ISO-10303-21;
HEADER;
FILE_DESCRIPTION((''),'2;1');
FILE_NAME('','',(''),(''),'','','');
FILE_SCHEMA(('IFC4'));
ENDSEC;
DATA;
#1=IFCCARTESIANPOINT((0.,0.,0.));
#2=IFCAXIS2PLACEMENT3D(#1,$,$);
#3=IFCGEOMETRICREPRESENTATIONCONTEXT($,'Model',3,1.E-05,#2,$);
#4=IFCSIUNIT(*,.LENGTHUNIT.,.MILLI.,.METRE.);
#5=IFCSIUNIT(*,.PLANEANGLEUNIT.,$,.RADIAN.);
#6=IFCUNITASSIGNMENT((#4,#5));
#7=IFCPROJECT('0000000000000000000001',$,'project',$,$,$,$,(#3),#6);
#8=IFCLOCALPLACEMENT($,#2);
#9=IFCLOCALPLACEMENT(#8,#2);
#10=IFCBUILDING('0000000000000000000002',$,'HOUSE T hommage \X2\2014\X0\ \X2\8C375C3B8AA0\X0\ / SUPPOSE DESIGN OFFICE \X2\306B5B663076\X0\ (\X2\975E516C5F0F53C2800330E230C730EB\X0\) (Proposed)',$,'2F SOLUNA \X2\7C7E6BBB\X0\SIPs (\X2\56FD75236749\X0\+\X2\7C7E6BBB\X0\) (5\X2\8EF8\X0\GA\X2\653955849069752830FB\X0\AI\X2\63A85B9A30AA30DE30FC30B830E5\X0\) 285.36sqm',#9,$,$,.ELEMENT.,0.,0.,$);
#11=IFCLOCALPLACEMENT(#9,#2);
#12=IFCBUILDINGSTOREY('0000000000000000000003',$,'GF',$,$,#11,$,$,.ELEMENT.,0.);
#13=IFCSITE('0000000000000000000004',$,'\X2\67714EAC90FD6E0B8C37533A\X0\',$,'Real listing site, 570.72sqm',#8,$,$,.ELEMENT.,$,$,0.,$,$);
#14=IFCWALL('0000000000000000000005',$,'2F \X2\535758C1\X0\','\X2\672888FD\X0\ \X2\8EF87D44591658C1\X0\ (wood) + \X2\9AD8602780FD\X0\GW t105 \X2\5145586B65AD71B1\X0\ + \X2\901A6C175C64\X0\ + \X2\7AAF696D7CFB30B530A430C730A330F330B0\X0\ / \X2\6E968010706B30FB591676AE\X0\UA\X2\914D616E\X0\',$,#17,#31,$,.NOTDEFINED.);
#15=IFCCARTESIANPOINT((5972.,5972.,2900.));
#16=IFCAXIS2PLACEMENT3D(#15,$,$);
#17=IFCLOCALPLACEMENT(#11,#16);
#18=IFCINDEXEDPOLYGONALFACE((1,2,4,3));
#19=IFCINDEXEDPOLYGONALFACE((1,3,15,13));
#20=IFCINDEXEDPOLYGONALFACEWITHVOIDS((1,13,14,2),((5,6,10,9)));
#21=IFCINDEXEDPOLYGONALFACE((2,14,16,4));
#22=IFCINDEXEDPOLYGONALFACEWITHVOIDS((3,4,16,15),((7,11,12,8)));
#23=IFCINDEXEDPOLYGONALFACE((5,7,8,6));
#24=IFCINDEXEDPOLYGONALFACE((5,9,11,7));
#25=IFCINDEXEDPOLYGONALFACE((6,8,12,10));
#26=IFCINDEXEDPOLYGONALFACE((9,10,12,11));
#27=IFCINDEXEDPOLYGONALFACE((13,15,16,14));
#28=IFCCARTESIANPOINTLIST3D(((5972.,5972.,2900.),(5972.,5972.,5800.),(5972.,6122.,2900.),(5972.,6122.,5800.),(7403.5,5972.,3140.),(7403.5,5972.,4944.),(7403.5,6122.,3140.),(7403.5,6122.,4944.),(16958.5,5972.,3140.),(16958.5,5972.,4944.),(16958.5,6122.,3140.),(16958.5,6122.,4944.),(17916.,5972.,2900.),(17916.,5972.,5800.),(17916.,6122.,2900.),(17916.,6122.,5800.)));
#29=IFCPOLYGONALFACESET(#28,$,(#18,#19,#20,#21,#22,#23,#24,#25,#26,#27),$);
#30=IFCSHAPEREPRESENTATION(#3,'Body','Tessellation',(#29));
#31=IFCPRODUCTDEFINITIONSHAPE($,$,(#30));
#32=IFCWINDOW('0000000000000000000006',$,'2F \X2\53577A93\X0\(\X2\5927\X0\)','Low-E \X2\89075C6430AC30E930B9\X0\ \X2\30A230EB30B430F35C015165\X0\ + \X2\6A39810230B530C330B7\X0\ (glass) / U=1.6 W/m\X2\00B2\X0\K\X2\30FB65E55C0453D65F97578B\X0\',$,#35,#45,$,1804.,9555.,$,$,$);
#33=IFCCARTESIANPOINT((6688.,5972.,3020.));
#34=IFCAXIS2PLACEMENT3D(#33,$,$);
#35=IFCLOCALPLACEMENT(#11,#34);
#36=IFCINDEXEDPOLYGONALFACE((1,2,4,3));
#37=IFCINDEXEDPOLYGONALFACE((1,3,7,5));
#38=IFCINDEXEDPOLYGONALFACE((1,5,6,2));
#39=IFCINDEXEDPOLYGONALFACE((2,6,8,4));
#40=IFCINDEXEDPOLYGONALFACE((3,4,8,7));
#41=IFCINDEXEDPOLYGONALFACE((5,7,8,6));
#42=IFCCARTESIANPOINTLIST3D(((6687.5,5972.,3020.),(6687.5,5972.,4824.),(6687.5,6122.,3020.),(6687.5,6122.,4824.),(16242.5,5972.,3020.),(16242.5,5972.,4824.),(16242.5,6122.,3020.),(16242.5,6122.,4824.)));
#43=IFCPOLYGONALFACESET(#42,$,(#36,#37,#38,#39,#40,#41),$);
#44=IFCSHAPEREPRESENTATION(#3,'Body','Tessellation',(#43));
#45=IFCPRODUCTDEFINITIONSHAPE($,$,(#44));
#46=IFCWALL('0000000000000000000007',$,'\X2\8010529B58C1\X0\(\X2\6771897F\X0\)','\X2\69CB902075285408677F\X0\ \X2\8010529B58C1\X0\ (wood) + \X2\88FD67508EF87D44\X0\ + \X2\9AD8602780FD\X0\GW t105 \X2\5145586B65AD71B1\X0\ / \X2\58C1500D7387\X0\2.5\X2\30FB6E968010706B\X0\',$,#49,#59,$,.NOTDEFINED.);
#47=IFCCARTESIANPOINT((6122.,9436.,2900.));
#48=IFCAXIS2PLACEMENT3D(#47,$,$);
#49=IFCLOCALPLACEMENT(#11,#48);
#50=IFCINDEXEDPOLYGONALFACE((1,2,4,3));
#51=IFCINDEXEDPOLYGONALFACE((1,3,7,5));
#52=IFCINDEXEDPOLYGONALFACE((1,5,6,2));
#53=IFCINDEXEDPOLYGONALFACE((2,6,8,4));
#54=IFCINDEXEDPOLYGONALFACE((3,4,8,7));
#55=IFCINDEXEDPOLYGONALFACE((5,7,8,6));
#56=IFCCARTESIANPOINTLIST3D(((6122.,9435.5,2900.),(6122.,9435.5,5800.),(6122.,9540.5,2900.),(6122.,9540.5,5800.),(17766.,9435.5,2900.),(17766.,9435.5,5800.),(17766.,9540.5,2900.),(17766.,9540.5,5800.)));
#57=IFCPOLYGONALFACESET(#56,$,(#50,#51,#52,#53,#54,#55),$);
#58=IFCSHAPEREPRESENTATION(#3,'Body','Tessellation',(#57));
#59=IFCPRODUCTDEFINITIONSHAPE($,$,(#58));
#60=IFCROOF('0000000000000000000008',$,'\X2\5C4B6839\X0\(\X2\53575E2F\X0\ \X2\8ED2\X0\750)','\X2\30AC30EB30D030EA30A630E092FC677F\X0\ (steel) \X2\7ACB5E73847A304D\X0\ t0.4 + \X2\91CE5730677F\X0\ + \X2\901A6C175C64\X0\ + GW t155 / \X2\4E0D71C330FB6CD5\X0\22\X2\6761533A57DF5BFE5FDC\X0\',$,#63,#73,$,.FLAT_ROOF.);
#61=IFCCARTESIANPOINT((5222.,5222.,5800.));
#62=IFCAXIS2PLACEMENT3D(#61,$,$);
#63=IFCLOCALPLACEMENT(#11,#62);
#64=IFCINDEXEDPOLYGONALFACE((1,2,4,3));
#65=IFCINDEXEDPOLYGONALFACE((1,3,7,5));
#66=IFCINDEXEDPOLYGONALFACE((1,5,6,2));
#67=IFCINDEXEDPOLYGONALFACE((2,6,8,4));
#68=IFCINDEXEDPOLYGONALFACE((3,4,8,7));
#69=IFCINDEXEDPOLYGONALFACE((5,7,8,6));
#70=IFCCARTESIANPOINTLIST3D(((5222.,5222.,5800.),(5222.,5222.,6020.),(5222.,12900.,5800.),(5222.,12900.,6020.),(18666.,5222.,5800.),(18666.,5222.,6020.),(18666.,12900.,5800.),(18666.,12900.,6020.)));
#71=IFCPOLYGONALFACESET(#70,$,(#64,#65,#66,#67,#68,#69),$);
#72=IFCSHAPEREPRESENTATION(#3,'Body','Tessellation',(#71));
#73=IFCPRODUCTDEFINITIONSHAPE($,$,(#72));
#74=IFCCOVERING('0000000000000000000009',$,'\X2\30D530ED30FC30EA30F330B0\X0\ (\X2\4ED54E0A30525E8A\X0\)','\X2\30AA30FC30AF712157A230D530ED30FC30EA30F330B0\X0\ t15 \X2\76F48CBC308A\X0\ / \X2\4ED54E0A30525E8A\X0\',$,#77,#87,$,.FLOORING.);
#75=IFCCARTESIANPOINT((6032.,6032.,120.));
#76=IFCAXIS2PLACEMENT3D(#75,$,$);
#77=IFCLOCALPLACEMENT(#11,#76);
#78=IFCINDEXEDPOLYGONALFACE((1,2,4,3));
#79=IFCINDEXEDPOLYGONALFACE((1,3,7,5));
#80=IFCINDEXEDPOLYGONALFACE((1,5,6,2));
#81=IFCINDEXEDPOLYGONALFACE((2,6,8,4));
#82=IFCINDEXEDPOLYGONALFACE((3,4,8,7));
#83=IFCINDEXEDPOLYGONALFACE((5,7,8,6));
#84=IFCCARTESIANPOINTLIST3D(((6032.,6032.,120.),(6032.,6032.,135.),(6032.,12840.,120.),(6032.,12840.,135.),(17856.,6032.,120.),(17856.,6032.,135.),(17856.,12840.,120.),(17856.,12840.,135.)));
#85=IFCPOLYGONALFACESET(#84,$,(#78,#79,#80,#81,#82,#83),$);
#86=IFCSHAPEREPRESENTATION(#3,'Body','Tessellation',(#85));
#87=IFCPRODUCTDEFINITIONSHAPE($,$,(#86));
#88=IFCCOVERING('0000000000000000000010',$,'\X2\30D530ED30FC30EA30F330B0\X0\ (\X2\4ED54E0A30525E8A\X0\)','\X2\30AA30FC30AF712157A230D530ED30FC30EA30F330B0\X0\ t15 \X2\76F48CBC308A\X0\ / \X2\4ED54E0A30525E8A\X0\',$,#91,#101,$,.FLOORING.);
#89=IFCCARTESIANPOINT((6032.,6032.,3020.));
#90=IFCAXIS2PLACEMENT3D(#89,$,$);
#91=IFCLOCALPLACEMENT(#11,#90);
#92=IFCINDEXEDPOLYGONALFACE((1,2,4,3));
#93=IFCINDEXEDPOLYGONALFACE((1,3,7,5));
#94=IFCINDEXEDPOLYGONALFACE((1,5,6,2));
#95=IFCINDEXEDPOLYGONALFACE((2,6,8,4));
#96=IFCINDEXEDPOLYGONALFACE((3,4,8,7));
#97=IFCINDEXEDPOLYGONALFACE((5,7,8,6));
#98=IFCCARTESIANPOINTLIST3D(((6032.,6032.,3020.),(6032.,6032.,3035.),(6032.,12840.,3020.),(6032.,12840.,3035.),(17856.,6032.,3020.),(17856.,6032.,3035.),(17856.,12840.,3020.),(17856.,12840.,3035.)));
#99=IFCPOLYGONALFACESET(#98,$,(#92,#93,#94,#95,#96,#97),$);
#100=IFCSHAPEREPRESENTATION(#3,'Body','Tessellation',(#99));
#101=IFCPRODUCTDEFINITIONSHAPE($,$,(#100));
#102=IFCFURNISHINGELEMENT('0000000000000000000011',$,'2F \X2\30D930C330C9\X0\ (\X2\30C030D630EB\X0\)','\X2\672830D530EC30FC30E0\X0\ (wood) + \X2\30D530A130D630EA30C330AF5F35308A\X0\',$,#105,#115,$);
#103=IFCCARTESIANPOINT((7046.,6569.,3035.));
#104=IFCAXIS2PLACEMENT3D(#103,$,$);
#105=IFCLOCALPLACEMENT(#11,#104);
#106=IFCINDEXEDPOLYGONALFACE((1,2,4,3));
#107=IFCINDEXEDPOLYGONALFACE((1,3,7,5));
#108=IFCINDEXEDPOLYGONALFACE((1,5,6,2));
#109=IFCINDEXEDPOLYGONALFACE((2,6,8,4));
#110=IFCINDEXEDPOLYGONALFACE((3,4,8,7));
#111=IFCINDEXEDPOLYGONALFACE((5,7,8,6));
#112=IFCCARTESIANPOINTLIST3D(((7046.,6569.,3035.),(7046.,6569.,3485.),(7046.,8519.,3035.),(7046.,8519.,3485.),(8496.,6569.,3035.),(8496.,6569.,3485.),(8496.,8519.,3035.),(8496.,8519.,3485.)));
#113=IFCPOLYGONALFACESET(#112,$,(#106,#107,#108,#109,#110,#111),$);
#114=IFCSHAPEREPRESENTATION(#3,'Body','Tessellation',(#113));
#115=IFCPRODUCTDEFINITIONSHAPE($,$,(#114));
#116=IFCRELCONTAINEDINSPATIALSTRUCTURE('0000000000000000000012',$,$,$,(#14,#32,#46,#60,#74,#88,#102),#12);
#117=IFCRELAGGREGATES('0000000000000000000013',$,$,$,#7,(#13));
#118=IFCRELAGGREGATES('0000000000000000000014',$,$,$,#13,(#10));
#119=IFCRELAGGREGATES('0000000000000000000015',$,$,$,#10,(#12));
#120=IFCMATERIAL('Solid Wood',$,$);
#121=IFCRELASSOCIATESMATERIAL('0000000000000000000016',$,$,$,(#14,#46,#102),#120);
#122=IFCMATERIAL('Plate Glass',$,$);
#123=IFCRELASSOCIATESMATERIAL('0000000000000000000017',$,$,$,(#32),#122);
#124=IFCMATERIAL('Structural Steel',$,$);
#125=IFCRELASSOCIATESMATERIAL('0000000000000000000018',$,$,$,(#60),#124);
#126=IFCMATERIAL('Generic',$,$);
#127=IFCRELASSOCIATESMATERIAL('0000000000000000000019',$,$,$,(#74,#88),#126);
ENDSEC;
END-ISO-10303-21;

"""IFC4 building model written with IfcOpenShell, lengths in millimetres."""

from ifc_helpers import new_model, si_unit, frame, frame_2d, origin, place, context, project, spatial, rectangle, extrude, material, element, fill, save


model = new_model("IFC4")

# Units and contexts
model_context = context("Model", 3, precision=1e-05, world=origin())
ifc_project = project(units=[si_unit("LENGTHUNIT", "METRE", prefix="MILLI"), si_unit("PLANEANGLEUNIT", "RADIAN")], contexts=[model_context])

# Site, building, storey
site_placement = place(None, origin())
site = spatial("IfcSite", under=ifc_project, at=site_placement, Name="東京都渋谷区", ObjectType="Real listing site, 570.72sqm", CompositionType="ELEMENT", RefElevation=0.0)
building_placement = place(site_placement, origin())
building = spatial("IfcBuilding", under=site, at=building_placement, Name="HOUSE T hommage — 谷尻誠 / SUPPOSE DESIGN OFFICE に学ぶ (非公式参考モデル) (Proposed)", ObjectType="2F SOLUNA 籾殻SIPs (国産杉+籾殻) (5軸GA改善適用・AI推定オマージュ) 285.36sqm", CompositionType="ELEMENT", ElevationOfRefHeight=0.0, ElevationOfTerrain=0.0)
storey_placement = place(building_placement, origin())
storey = spatial("IfcBuildingStorey", under=building, at=storey_placement, Name="GF", CompositionType="ELEMENT", Elevation=0.0)

# Shared definitions
ifc_material_1 = material(Name="Solid Wood")

# Shared definitions
ifc_material_2 = material(Name="Plate Glass")

# Wall, opening, window
wall_1_placement = place(storey_placement, frame((5972.0, 5972.0, 2900.0)))
wall_1 = element("IfcWall", 1, at=wall_1_placement, inside=storey, material=ifc_material_1, Name="2F 南壁", Description="木製 軸組外壁 (wood) + 高性能GW t105 充填断熱 + 通気層 + 窯業系サイディング / 準耐火・外皮UA配慮", PredefinedType="NOTDEFINED", context=model_context, shape_type="SweptSolid", body=[
    extrude(rectangle(XDim=11944.0, YDim=150.0, at=frame_2d((5972.0, 75.0))), frame((5972.0, 5972.0, 2900.0)), (0.0, 0.0, 1.0), 2900.0),
])
opening_1_placement = place(storey_placement, frame((6688.0, 5972.0, 3020.0)))
opening_1 = element("IfcOpeningElement", 2, at=opening_1_placement, cuts=wall_1, PredefinedType="NOTDEFINED", context=model_context, shape_type="SweptSolid", body=[
    extrude(rectangle(XDim=9555.0, YDim=150.0, at=frame_2d((4777.0, 75.0))), frame((6688.0, 5972.0, 3020.0)), (0.0, 0.0, 1.0), 1804.0),
])
window_1_placement = place(storey_placement, frame((6688.0, 5972.0, 3020.0)))
window_1 = element("IfcWindow", 3, at=window_1_placement, inside=storey, material=ifc_material_2, Name="2F 南窓(大)", Description="Low-E 複層ガラス アルゴン封入 + 樹脂サッシ (glass) / U=1.6 W/m²K・日射取得型", OverallHeight=1804.0, OverallWidth=9555.0, context=model_context, shape_type="SweptSolid", body=[
    extrude(rectangle(XDim=9555.0, YDim=150.0, at=frame_2d((4777.0, 75.0))), frame((6688.0, 5972.0, 3020.0)), (0.0, 0.0, 1.0), 1804.0),
])
fill(opening_1, window_1)

# Wall
wall_2_placement = place(storey_placement, frame((6122.0, 9436.0, 2900.0)))
element("IfcWall", 4, at=wall_2_placement, inside=storey, material=ifc_material_1, Name="耐力壁(東西)", Description="構造用合板 耐力壁 (wood) + 製材軸組 + 高性能GW t105 充填断熱 / 壁倍率2.5・準耐火", PredefinedType="NOTDEFINED", context=model_context, shape_type="SweptSolid", body=[
    extrude(rectangle(XDim=11644.0, YDim=105.0, at=frame_2d((5822.0, 52.0))), frame((6122.0, 9436.0, 2900.0)), (0.0, 0.0, 1.0), 2900.0),
])

# Roof
ifc_material_3 = material(Name="Structural Steel")
for number, where, name in (
    (5, (5222.0, 5222.0, 5800.0), "屋根(南帯 軒750)"),
):
    element("IfcRoof", number, at=place(storey_placement, frame(where)), inside=storey, material=ifc_material_3, Name=name, Description="ガルバリウム鋼板 (steel) 立平葺き t0.4 + 野地板 + 通気層 + GW t155 / 不燃・法22条区域対応", PredefinedType="FLAT_ROOF", context=model_context, shape_type="SweptSolid", body=[
        extrude(rectangle(XDim=13444.0, YDim=7678.0, at=frame_2d((6722.0, 3839.0))), frame((5222.0, 5222.0, 5800.0)), (0.0, 0.0, 1.0), 220.0),
    ])

# Coverings
ifc_material_4 = material(Name="Generic")
covering_1_placement = place(storey_placement, frame((6032.0, 6032.0, 120.0)))
element("IfcCovering", 6, at=covering_1_placement, inside=storey, material=ifc_material_4, Name="フローリング (仕上げ床)", Description="オーク無垢フローリング t15 直貼り / 仕上げ床", PredefinedType="FLOORING", context=model_context, shape_type="SweptSolid", body=[
    extrude(rectangle(XDim=11824.0, YDim=6808.0, at=frame_2d((5912.0, 3404.0))), frame((6032.0, 6032.0, 120.0)), (0.0, 0.0, 1.0), 15.0),
])
covering_2_placement = place(storey_placement, frame((6032.0, 6032.0, 3020.0)))
element("IfcCovering", 7, at=covering_2_placement, inside=storey, material=ifc_material_4, Name="フローリング (仕上げ床)", Description="オーク無垢フローリング t15 直貼り / 仕上げ床", PredefinedType="FLOORING", context=model_context, shape_type="SweptSolid", body=[
    extrude(rectangle(XDim=11824.0, YDim=6808.0, at=frame_2d((5912.0, 3404.0))), frame((6032.0, 6032.0, 3020.0)), (0.0, 0.0, 1.0), 15.0),
])

# Furnishing element
furnishing_placement = place(storey_placement, frame((7046.0, 6569.0, 3035.0)))
element("IfcFurnishingElement", 8, at=furnishing_placement, inside=storey, material=ifc_material_1, Name="2F ベッド (ダブル)", Description="木フレーム (wood) + ファブリック張り", context=model_context, shape_type="SweptSolid", body=[
    extrude(rectangle(XDim=1450.0, YDim=1950.0, at=frame_2d((725.0, 975.0))), frame((7046.0, 6569.0, 3035.0)), (0.0, 0.0, 1.0), 450.0),
])

save(model, "model.ifc")
